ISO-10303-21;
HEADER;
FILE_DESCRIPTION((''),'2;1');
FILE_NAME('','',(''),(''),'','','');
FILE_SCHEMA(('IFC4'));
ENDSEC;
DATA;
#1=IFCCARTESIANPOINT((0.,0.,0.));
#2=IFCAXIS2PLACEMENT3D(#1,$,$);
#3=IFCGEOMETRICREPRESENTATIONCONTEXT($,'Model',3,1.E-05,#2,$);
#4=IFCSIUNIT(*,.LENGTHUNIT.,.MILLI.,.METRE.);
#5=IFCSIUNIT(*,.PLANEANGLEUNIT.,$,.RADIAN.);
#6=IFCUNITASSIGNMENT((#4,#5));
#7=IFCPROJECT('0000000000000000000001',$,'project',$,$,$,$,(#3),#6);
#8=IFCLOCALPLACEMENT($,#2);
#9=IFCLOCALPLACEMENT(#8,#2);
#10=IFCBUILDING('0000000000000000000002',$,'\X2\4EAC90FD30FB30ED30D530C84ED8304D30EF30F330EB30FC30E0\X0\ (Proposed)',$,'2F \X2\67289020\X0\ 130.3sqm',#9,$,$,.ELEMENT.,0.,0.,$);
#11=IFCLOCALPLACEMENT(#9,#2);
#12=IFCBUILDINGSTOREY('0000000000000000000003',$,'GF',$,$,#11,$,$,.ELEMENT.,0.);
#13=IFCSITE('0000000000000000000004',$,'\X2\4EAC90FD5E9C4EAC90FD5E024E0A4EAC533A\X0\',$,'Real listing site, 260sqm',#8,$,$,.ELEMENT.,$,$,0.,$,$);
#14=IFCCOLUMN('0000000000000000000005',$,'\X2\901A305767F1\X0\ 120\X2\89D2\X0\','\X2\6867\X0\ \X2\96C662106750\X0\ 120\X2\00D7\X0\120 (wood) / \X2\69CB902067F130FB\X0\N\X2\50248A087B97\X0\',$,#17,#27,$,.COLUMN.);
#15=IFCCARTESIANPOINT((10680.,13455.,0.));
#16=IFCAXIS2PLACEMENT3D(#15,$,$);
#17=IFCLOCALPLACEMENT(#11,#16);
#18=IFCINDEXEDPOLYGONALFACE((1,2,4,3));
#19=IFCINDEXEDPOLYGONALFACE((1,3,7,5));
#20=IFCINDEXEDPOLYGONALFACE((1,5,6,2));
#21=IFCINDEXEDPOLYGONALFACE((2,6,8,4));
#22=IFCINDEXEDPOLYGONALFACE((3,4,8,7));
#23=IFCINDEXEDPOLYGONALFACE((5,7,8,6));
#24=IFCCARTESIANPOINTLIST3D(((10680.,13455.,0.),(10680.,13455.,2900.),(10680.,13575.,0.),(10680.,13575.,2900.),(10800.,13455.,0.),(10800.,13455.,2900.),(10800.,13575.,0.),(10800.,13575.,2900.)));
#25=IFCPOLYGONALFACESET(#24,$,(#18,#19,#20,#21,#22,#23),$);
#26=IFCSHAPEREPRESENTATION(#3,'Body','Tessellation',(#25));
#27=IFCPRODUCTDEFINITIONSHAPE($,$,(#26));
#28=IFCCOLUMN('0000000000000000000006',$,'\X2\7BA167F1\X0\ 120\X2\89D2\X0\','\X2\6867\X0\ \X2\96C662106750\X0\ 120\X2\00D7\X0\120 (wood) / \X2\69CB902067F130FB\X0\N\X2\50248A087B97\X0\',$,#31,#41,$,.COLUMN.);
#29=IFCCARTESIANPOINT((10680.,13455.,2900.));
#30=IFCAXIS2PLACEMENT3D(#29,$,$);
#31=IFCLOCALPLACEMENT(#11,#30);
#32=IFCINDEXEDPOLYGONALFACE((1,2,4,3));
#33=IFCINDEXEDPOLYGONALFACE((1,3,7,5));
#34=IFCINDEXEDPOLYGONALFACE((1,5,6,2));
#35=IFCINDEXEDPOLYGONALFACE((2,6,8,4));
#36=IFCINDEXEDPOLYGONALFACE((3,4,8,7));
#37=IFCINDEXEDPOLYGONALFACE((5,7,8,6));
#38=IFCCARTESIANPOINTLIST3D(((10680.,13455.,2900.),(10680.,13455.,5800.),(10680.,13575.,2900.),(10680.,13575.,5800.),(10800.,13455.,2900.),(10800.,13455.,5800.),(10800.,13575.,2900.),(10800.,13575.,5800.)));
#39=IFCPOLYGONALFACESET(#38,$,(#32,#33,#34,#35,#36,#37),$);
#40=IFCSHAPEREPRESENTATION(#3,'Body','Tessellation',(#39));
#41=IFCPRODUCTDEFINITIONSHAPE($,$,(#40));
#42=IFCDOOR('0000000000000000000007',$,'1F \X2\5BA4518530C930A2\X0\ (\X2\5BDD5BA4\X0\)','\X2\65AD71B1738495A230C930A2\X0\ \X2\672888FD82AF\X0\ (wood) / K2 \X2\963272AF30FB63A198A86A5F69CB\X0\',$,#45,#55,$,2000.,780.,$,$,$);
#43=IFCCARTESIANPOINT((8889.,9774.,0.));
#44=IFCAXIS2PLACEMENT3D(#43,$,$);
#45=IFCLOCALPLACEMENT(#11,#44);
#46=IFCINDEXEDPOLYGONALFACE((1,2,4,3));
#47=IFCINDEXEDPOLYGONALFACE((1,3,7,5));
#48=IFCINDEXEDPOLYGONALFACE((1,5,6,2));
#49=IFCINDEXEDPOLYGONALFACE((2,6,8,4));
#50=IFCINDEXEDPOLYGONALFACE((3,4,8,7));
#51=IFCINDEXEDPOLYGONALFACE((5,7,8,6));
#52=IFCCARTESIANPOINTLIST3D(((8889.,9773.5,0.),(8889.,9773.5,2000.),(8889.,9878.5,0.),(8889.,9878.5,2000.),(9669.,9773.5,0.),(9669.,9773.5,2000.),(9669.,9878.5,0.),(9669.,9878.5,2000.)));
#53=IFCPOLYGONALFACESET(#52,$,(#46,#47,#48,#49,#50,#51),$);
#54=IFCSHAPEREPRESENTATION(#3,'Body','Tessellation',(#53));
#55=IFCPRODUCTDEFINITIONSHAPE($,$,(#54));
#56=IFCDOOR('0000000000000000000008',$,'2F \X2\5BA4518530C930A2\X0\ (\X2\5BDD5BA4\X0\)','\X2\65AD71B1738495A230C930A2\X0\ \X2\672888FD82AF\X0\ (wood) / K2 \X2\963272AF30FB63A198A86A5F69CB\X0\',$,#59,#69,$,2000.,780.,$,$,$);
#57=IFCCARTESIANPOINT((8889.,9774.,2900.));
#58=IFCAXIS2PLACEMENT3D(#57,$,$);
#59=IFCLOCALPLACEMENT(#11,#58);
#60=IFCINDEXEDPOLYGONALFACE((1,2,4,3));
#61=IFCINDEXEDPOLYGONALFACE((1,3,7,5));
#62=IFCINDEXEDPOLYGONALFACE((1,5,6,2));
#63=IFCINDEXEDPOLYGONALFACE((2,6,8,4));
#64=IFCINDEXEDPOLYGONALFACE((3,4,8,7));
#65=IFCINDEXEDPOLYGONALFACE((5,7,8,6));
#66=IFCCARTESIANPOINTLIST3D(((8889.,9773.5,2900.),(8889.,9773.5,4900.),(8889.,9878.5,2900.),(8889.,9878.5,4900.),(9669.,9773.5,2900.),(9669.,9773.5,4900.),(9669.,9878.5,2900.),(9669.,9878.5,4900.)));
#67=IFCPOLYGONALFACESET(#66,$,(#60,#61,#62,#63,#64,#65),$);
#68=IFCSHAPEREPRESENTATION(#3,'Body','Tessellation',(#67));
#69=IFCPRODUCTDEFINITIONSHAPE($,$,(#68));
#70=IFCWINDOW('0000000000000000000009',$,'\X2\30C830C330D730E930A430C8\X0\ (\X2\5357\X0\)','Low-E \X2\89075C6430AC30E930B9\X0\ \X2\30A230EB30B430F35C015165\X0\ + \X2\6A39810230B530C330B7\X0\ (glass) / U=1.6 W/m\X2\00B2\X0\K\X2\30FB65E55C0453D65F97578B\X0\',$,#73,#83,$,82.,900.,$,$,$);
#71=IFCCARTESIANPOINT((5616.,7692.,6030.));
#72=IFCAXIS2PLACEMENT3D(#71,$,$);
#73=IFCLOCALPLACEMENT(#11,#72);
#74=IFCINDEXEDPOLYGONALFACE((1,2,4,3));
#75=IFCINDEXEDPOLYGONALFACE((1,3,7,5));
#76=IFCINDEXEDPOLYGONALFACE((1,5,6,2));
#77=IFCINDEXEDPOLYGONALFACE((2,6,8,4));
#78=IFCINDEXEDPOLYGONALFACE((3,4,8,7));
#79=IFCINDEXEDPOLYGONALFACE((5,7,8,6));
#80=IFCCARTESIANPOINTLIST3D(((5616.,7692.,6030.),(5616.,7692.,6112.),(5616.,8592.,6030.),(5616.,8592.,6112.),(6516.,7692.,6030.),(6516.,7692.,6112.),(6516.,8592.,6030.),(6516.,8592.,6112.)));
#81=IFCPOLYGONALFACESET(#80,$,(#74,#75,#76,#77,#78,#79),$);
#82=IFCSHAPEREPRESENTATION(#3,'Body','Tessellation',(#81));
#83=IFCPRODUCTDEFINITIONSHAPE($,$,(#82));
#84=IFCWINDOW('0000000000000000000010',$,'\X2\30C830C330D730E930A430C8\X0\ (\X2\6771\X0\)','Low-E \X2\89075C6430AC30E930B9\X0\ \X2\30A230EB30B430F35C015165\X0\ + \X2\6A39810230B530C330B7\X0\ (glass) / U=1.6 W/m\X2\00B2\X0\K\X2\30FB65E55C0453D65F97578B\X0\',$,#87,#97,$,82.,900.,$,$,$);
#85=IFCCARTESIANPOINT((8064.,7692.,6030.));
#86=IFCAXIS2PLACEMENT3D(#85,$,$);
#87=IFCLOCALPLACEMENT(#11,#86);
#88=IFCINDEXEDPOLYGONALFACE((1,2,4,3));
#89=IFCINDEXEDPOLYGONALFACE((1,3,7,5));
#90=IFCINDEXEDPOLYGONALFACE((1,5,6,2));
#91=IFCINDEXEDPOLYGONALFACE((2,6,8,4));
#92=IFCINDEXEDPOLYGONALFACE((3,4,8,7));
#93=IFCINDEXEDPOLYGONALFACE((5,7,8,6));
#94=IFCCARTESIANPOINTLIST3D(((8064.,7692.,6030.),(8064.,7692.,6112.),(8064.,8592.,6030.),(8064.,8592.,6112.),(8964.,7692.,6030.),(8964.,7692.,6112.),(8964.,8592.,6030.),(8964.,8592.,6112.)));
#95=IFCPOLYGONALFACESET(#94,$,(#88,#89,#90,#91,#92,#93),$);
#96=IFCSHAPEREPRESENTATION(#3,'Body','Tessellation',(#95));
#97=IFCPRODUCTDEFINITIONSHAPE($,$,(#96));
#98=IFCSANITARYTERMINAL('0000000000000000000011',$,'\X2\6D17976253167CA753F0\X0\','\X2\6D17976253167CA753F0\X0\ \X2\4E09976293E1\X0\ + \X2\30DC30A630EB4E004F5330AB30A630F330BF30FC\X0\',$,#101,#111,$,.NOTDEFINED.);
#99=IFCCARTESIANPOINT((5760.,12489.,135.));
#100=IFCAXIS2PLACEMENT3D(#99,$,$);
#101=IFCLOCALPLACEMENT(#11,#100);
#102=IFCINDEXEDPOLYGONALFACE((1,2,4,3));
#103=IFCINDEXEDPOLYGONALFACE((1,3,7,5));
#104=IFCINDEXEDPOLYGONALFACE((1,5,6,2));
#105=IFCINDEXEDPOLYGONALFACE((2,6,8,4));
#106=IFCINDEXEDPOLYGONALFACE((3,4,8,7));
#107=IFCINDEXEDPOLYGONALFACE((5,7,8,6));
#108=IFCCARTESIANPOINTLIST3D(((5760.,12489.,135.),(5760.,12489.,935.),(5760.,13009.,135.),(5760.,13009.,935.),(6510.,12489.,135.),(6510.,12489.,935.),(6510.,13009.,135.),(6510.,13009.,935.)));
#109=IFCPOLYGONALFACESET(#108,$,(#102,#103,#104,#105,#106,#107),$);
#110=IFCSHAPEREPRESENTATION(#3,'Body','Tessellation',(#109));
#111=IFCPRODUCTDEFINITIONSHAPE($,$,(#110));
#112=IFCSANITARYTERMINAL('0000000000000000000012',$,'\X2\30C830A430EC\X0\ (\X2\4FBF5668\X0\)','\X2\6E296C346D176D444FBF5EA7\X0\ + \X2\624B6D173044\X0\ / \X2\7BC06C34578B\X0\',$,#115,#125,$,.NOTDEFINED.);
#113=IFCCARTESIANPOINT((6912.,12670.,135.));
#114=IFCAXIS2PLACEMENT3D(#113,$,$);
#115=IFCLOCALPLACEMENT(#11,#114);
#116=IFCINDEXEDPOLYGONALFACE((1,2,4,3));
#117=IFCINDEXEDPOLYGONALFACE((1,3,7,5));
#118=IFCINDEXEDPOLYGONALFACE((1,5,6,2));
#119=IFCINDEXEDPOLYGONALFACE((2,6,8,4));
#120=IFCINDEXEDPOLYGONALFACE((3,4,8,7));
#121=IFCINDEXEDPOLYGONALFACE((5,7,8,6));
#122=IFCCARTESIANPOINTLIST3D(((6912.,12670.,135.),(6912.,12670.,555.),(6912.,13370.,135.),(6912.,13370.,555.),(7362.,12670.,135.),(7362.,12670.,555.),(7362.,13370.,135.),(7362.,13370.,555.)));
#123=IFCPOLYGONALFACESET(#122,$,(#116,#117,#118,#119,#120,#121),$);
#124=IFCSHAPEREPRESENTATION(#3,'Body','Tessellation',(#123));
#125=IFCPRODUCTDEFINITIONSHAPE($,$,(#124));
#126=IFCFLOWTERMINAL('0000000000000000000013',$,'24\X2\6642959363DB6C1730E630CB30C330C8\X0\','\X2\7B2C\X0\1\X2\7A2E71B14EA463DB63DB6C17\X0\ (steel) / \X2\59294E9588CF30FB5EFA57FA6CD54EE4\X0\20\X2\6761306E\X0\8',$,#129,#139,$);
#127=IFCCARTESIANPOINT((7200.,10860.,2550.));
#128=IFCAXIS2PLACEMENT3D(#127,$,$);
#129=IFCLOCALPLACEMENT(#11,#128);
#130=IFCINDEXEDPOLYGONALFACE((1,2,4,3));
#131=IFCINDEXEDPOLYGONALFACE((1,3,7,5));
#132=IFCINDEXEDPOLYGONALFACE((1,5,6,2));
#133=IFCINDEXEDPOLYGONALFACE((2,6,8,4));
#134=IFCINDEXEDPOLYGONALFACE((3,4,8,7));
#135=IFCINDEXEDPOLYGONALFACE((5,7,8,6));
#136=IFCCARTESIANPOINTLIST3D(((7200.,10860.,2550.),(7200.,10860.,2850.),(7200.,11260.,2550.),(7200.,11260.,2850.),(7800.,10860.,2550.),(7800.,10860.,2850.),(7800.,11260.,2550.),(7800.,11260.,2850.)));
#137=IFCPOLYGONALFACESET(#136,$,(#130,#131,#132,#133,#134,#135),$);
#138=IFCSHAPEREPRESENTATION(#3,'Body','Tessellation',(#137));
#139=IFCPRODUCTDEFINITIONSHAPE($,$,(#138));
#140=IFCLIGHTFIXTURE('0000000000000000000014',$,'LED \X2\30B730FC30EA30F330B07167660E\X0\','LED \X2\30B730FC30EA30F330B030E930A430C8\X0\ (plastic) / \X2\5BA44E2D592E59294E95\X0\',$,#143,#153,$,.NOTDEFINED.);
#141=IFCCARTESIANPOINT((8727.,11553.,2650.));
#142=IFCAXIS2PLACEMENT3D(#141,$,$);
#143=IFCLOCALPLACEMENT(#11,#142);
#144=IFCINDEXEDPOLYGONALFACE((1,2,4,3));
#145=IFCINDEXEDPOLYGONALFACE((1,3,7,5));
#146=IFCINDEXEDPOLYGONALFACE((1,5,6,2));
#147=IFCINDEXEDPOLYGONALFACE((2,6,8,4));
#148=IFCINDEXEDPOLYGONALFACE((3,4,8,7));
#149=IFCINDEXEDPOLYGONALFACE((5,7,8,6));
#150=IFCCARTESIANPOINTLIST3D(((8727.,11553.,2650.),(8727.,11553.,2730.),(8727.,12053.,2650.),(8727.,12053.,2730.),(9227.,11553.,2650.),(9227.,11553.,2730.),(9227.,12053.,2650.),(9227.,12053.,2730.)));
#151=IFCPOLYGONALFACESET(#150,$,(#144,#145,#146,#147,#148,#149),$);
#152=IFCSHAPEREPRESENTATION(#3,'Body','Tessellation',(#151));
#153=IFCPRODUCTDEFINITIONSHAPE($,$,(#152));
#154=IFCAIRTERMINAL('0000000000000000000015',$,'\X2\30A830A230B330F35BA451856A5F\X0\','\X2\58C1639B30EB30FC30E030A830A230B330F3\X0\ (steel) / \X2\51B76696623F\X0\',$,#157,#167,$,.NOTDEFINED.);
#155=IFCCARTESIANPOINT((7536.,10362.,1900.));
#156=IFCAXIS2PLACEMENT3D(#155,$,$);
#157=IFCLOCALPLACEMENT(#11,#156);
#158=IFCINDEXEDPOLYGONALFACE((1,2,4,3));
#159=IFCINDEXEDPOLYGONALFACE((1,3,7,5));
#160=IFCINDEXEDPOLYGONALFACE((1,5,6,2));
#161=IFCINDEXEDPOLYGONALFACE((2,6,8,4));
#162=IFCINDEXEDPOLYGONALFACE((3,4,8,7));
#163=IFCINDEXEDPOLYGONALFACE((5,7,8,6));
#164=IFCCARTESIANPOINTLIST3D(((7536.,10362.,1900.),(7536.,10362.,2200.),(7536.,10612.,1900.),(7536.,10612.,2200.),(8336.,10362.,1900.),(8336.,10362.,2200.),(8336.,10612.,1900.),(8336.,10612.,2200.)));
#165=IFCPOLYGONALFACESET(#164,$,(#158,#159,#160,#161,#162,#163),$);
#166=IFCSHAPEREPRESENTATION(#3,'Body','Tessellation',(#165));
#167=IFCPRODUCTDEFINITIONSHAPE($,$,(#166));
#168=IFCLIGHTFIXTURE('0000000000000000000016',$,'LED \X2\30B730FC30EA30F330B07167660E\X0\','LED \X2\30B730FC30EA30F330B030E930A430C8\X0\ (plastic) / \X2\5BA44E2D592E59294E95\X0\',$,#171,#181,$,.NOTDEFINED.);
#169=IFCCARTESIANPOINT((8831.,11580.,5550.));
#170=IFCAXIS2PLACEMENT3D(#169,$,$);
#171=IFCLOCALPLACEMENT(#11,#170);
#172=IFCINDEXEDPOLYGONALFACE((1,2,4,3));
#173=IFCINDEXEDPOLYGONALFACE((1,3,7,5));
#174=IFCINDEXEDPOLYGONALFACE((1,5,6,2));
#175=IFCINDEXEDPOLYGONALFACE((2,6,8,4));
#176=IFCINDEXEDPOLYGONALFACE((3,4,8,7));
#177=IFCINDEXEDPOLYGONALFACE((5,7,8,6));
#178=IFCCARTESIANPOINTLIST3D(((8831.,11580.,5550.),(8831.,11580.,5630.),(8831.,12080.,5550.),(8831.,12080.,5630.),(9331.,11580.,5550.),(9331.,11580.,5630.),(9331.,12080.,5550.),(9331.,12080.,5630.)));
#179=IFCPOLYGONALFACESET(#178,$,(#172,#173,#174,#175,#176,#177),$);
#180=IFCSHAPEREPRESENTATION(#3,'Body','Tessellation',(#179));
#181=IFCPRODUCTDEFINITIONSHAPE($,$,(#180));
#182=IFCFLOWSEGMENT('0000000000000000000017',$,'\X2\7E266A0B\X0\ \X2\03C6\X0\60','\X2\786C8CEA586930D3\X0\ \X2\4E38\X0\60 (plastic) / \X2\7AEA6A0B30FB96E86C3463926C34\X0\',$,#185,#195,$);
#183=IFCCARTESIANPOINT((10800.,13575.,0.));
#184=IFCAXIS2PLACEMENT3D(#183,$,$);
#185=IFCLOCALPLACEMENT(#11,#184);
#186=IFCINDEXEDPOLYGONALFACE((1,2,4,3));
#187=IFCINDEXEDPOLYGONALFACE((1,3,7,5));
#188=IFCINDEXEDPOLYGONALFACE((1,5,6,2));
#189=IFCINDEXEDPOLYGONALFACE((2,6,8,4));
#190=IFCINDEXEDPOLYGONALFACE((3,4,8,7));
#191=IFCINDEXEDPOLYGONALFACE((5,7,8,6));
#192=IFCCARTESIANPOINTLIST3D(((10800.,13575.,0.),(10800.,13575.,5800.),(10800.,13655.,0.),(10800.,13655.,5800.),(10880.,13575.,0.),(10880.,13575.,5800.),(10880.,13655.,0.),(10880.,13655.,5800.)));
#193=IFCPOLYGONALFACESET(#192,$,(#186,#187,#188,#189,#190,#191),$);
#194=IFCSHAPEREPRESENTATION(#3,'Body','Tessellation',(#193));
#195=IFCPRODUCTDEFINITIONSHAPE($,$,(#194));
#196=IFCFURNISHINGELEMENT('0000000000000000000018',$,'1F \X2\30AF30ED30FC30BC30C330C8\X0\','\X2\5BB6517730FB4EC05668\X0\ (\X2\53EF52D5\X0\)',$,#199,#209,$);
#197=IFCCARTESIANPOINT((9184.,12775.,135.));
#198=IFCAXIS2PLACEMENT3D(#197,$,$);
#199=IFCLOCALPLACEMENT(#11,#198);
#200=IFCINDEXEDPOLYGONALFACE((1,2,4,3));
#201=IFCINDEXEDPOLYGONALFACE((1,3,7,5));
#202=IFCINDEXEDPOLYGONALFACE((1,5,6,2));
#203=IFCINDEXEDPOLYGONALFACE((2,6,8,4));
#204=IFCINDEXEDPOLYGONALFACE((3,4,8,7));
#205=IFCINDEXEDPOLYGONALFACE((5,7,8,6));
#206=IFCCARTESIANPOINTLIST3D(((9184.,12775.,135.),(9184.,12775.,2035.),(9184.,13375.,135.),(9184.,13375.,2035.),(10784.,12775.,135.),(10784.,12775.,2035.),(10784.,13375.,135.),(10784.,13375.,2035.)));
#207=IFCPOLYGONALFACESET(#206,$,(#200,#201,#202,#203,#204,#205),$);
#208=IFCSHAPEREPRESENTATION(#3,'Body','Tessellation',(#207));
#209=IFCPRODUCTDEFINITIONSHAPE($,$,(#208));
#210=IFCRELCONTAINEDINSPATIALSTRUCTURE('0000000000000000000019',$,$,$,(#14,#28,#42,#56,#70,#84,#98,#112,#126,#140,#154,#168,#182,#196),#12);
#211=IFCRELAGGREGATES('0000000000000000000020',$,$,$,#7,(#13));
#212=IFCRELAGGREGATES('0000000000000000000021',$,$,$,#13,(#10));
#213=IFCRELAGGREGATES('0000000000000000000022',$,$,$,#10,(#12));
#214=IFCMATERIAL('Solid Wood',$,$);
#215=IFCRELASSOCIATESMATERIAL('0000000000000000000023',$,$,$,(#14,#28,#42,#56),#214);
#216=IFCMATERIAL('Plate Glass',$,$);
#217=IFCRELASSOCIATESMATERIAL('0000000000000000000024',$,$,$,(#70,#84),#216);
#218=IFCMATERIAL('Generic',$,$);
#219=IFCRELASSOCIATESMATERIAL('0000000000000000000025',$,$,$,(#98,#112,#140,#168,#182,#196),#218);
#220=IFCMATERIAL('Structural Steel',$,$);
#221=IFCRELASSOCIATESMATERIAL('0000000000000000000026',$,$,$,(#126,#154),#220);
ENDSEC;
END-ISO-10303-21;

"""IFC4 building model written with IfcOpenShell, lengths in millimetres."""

from ifc_helpers import new_model, si_unit, frame, frame_2d, origin, place, context, project, spatial, rectangle, extrude, material, element, save


model = new_model("IFC4")

# Units and contexts
model_context = context("Model", 3, precision=1e-05, world=origin())
ifc_project = project(units=[si_unit("LENGTHUNIT", "METRE", prefix="MILLI"), si_unit("PLANEANGLEUNIT", "RADIAN")], contexts=[model_context])

# Site, building, storey
site_placement = place(None, origin())
site = spatial("IfcSite", under=ifc_project, at=site_placement, Name="京都府京都市上京区", ObjectType="Real listing site, 260sqm", CompositionType="ELEMENT", RefElevation=0.0)
building_placement = place(site_placement, origin())
building = spatial("IfcBuilding", under=site, at=building_placement, Name="京都・ロフト付きワンルーム (Proposed)", ObjectType="2F 木造 130.3sqm", CompositionType="ELEMENT", ElevationOfRefHeight=0.0, ElevationOfTerrain=0.0)
storey_placement = place(building_placement, origin())
storey = spatial("IfcBuildingStorey", under=building, at=storey_placement, Name="GF", CompositionType="ELEMENT", Elevation=0.0)

# Columns
ifc_material_1 = material(Name="Solid Wood")
column_1_placement = place(storey_placement, frame((10680.0, 13455.0, 0.0)))
element("IfcColumn", 1, at=column_1_placement, inside=storey, material=ifc_material_1, Name="通し柱 120角", Description="桧 集成材 120×120 (wood) / 構造柱・N値計算", PredefinedType="COLUMN", context=model_context, shape_type="SweptSolid", body=[
    extrude(rectangle(XDim=120.0, YDim=120.0, at=frame_2d((60.0, 60.0))), frame((10680.0, 13455.0, 0.0)), (0.0, 0.0, 1.0), 2900.0),
])
column_2_placement = place(storey_placement, frame((10680.0, 13455.0, 2900.0)))
element("IfcColumn", 2, at=column_2_placement, inside=storey, material=ifc_material_1, Name="管柱 120角", Description="桧 集成材 120×120 (wood) / 構造柱・N値計算", PredefinedType="COLUMN", context=model_context, shape_type="SweptSolid", body=[
    extrude(rectangle(XDim=120.0, YDim=120.0, at=frame_2d((60.0, 60.0))), frame((10680.0, 13455.0, 2900.0)), (0.0, 0.0, 1.0), 2900.0),
])

# Door
door_1_placement = place(storey_placement, frame((8889.0, 9774.0, 0.0)))
element("IfcDoor", 3, at=door_1_placement, inside=storey, material=ifc_material_1, Name="1F 室内ドア (寝室)", Description="断熱玄関ドア 木製芯 (wood) / K2 防犯・採風機構", OverallHeight=2000.0, OverallWidth=780.0, context=model_context, shape_type="SweptSolid", body=[
    extrude(rectangle(XDim=780.0, YDim=105.0, at=frame_2d((390.0, 52.0))), frame((8889.0, 9774.0, 0.0)), (0.0, 0.0, 1.0), 2000.0),
])

# Door
door_2_placement = place(storey_placement, frame((8889.0, 9774.0, 2900.0)))
element("IfcDoor", 4, at=door_2_placement, inside=storey, material=ifc_material_1, Name="2F 室内ドア (寝室)", Description="断熱玄関ドア 木製芯 (wood) / K2 防犯・採風機構", OverallHeight=2000.0, OverallWidth=780.0, context=model_context, shape_type="SweptSolid", body=[
    extrude(rectangle(XDim=780.0, YDim=105.0, at=frame_2d((390.0, 52.0))), frame((8889.0, 9774.0, 2900.0)), (0.0, 0.0, 1.0), 2000.0),
])

# Windows
ifc_material_2 = material(Name="Plate Glass")
window_1_placement = place(storey_placement, frame((5616.0, 7692.0, 6030.0)))
element("IfcWindow", 5, at=window_1_placement, inside=storey, material=ifc_material_2, Name="トップライト (南)", Description="Low-E 複層ガラス アルゴン封入 + 樹脂サッシ (glass) / U=1.6 W/m²K・日射取得型", OverallHeight=82.0, OverallWidth=900.0, context=model_context, shape_type="SweptSolid", body=[
    extrude(rectangle(XDim=900.0, YDim=900.0, at=frame_2d((450.0, 450.0))), frame((5616.0, 7692.0, 6030.0)), (0.0, 0.0, 1.0), 82.0),
])
window_2_placement = place(storey_placement, frame((8064.0, 7692.0, 6030.0)))
element("IfcWindow", 6, at=window_2_placement, inside=storey, material=ifc_material_2, Name="トップライト (東)", Description="Low-E 複層ガラス アルゴン封入 + 樹脂サッシ (glass) / U=1.6 W/m²K・日射取得型", OverallHeight=82.0, OverallWidth=900.0, context=model_context, shape_type="SweptSolid", body=[
    extrude(rectangle(XDim=900.0, YDim=900.0, at=frame_2d((450.0, 450.0))), frame((8064.0, 7692.0, 6030.0)), (0.0, 0.0, 1.0), 82.0),
])

# Sanitary terminals
ifc_material_3 = material(Name="Generic")
sanitary_terminal_1_placement = place(storey_placement, frame((5760.0, 12489.0, 135.0)))
element("IfcSanitaryTerminal", 7, at=sanitary_terminal_1_placement, inside=storey, material=ifc_material_3, Name="洗面化粧台", Description="洗面化粧台 三面鏡 + ボウル一体カウンター", PredefinedType="NOTDEFINED", context=model_context, shape_type="SweptSolid", body=[
    extrude(rectangle(XDim=750.0, YDim=520.0, at=frame_2d((375.0, 260.0))), frame((5760.0, 12489.0, 135.0)), (0.0, 0.0, 1.0), 800.0),
])
sanitary_terminal_2_placement = place(storey_placement, frame((6912.0, 12670.0, 135.0)))
element("IfcSanitaryTerminal", 8, at=sanitary_terminal_2_placement, inside=storey, material=ifc_material_3, Name="トイレ (便器)", Description="温水洗浄便座 + 手洗い / 節水型", PredefinedType="NOTDEFINED", context=model_context, shape_type="SweptSolid", body=[
    extrude(rectangle(XDim=450.0, YDim=700.0, at=frame_2d((225.0, 350.0))), frame((6912.0, 12670.0, 135.0)), (0.0, 0.0, 1.0), 420.0),
])

# Flow terminal
ifc_material_4 = material(Name="Structural Steel")
flow_terminal_placement = place(storey_placement, frame((7200.0, 10860.0, 2550.0)))
element("IfcFlowTerminal", 9, at=flow_terminal_placement, inside=storey, material=ifc_material_4, Name="24時間換気ユニット", Description="第1種熱交換換気 (steel) / 天井裏・建基法令20条の8", context=model_context, shape_type="SweptSolid", body=[
    extrude(rectangle(XDim=600.0, YDim=400.0, at=frame_2d((300.0, 200.0))), frame((7200.0, 10860.0, 2550.0)), (0.0, 0.0, 1.0), 300.0),
])

# Light fixture
light_fixture_1_placement = place(storey_placement, frame((8727.0, 11553.0, 2650.0)))
element("IfcLightFixture", 10, at=light_fixture_1_placement, inside=storey, material=ifc_material_3, Name="LED シーリング照明", Description="LED シーリングライト (plastic) / 室中央天井", PredefinedType="NOTDEFINED", context=model_context, shape_type="SweptSolid", body=[
    extrude(rectangle(XDim=500.0, YDim=500.0, at=frame_2d((250.0, 250.0))), frame((8727.0, 11553.0, 2650.0)), (0.0, 0.0, 1.0), 80.0),
])

# Air terminal
air_terminal_placement = place(storey_placement, frame((7536.0, 10362.0, 1900.0)))
element("IfcAirTerminal", 11, at=air_terminal_placement, inside=storey, material=ifc_material_4, Name="エアコン室内機", Description="壁掛ルームエアコン (steel) / 冷暖房", PredefinedType="NOTDEFINED", context=model_context, shape_type="SweptSolid", body=[
    extrude(rectangle(XDim=800.0, YDim=250.0, at=frame_2d((400.0, 125.0))), frame((7536.0, 10362.0, 1900.0)), (0.0, 0.0, 1.0), 300.0),
])

# Light fixture
light_fixture_2_placement = place(storey_placement, frame((8831.0, 11580.0, 5550.0)))
element("IfcLightFixture", 12, at=light_fixture_2_placement, inside=storey, material=ifc_material_3, Name="LED シーリング照明", Description="LED シーリングライト (plastic) / 室中央天井", PredefinedType="NOTDEFINED", context=model_context, shape_type="SweptSolid", body=[
    extrude(rectangle(XDim=500.0, YDim=500.0, at=frame_2d((250.0, 250.0))), frame((8831.0, 11580.0, 5550.0)), (0.0, 0.0, 1.0), 80.0),
])

# Flow segment
flow_segment_placement = place(storey_placement, frame((10800.0, 13575.0, 0.0)))
element("IfcFlowSegment", 13, at=flow_segment_placement, inside=storey, material=ifc_material_3, Name="縦樋 φ60", Description="硬質塩ビ 丸60 (plastic) / 竪樋・雨水排水", context=model_context, shape_type="SweptSolid", body=[
    extrude(rectangle(XDim=80.0, YDim=80.0, at=frame_2d((40.0, 40.0))), frame((10800.0, 13575.0, 0.0)), (0.0, 0.0, 1.0), 5800.0),
])

# Furnishing element
furnishing_1_placement = place(storey_placement, frame((9184.0, 12775.0, 135.0)))
element("IfcFurnishingElement", 14, at=furnishing_1_placement, inside=storey, material=ifc_material_3, Name="1F クローゼット", Description="家具・什器 (可動)", context=model_context, shape_type="SweptSolid", body=[
    extrude(rectangle(XDim=1600.0, YDim=600.0, at=frame_2d((800.0, 300.0))), frame((9184.0, 12775.0, 135.0)), (0.0, 0.0, 1.0), 1900.0),
])

save(model, "model.ifc")
